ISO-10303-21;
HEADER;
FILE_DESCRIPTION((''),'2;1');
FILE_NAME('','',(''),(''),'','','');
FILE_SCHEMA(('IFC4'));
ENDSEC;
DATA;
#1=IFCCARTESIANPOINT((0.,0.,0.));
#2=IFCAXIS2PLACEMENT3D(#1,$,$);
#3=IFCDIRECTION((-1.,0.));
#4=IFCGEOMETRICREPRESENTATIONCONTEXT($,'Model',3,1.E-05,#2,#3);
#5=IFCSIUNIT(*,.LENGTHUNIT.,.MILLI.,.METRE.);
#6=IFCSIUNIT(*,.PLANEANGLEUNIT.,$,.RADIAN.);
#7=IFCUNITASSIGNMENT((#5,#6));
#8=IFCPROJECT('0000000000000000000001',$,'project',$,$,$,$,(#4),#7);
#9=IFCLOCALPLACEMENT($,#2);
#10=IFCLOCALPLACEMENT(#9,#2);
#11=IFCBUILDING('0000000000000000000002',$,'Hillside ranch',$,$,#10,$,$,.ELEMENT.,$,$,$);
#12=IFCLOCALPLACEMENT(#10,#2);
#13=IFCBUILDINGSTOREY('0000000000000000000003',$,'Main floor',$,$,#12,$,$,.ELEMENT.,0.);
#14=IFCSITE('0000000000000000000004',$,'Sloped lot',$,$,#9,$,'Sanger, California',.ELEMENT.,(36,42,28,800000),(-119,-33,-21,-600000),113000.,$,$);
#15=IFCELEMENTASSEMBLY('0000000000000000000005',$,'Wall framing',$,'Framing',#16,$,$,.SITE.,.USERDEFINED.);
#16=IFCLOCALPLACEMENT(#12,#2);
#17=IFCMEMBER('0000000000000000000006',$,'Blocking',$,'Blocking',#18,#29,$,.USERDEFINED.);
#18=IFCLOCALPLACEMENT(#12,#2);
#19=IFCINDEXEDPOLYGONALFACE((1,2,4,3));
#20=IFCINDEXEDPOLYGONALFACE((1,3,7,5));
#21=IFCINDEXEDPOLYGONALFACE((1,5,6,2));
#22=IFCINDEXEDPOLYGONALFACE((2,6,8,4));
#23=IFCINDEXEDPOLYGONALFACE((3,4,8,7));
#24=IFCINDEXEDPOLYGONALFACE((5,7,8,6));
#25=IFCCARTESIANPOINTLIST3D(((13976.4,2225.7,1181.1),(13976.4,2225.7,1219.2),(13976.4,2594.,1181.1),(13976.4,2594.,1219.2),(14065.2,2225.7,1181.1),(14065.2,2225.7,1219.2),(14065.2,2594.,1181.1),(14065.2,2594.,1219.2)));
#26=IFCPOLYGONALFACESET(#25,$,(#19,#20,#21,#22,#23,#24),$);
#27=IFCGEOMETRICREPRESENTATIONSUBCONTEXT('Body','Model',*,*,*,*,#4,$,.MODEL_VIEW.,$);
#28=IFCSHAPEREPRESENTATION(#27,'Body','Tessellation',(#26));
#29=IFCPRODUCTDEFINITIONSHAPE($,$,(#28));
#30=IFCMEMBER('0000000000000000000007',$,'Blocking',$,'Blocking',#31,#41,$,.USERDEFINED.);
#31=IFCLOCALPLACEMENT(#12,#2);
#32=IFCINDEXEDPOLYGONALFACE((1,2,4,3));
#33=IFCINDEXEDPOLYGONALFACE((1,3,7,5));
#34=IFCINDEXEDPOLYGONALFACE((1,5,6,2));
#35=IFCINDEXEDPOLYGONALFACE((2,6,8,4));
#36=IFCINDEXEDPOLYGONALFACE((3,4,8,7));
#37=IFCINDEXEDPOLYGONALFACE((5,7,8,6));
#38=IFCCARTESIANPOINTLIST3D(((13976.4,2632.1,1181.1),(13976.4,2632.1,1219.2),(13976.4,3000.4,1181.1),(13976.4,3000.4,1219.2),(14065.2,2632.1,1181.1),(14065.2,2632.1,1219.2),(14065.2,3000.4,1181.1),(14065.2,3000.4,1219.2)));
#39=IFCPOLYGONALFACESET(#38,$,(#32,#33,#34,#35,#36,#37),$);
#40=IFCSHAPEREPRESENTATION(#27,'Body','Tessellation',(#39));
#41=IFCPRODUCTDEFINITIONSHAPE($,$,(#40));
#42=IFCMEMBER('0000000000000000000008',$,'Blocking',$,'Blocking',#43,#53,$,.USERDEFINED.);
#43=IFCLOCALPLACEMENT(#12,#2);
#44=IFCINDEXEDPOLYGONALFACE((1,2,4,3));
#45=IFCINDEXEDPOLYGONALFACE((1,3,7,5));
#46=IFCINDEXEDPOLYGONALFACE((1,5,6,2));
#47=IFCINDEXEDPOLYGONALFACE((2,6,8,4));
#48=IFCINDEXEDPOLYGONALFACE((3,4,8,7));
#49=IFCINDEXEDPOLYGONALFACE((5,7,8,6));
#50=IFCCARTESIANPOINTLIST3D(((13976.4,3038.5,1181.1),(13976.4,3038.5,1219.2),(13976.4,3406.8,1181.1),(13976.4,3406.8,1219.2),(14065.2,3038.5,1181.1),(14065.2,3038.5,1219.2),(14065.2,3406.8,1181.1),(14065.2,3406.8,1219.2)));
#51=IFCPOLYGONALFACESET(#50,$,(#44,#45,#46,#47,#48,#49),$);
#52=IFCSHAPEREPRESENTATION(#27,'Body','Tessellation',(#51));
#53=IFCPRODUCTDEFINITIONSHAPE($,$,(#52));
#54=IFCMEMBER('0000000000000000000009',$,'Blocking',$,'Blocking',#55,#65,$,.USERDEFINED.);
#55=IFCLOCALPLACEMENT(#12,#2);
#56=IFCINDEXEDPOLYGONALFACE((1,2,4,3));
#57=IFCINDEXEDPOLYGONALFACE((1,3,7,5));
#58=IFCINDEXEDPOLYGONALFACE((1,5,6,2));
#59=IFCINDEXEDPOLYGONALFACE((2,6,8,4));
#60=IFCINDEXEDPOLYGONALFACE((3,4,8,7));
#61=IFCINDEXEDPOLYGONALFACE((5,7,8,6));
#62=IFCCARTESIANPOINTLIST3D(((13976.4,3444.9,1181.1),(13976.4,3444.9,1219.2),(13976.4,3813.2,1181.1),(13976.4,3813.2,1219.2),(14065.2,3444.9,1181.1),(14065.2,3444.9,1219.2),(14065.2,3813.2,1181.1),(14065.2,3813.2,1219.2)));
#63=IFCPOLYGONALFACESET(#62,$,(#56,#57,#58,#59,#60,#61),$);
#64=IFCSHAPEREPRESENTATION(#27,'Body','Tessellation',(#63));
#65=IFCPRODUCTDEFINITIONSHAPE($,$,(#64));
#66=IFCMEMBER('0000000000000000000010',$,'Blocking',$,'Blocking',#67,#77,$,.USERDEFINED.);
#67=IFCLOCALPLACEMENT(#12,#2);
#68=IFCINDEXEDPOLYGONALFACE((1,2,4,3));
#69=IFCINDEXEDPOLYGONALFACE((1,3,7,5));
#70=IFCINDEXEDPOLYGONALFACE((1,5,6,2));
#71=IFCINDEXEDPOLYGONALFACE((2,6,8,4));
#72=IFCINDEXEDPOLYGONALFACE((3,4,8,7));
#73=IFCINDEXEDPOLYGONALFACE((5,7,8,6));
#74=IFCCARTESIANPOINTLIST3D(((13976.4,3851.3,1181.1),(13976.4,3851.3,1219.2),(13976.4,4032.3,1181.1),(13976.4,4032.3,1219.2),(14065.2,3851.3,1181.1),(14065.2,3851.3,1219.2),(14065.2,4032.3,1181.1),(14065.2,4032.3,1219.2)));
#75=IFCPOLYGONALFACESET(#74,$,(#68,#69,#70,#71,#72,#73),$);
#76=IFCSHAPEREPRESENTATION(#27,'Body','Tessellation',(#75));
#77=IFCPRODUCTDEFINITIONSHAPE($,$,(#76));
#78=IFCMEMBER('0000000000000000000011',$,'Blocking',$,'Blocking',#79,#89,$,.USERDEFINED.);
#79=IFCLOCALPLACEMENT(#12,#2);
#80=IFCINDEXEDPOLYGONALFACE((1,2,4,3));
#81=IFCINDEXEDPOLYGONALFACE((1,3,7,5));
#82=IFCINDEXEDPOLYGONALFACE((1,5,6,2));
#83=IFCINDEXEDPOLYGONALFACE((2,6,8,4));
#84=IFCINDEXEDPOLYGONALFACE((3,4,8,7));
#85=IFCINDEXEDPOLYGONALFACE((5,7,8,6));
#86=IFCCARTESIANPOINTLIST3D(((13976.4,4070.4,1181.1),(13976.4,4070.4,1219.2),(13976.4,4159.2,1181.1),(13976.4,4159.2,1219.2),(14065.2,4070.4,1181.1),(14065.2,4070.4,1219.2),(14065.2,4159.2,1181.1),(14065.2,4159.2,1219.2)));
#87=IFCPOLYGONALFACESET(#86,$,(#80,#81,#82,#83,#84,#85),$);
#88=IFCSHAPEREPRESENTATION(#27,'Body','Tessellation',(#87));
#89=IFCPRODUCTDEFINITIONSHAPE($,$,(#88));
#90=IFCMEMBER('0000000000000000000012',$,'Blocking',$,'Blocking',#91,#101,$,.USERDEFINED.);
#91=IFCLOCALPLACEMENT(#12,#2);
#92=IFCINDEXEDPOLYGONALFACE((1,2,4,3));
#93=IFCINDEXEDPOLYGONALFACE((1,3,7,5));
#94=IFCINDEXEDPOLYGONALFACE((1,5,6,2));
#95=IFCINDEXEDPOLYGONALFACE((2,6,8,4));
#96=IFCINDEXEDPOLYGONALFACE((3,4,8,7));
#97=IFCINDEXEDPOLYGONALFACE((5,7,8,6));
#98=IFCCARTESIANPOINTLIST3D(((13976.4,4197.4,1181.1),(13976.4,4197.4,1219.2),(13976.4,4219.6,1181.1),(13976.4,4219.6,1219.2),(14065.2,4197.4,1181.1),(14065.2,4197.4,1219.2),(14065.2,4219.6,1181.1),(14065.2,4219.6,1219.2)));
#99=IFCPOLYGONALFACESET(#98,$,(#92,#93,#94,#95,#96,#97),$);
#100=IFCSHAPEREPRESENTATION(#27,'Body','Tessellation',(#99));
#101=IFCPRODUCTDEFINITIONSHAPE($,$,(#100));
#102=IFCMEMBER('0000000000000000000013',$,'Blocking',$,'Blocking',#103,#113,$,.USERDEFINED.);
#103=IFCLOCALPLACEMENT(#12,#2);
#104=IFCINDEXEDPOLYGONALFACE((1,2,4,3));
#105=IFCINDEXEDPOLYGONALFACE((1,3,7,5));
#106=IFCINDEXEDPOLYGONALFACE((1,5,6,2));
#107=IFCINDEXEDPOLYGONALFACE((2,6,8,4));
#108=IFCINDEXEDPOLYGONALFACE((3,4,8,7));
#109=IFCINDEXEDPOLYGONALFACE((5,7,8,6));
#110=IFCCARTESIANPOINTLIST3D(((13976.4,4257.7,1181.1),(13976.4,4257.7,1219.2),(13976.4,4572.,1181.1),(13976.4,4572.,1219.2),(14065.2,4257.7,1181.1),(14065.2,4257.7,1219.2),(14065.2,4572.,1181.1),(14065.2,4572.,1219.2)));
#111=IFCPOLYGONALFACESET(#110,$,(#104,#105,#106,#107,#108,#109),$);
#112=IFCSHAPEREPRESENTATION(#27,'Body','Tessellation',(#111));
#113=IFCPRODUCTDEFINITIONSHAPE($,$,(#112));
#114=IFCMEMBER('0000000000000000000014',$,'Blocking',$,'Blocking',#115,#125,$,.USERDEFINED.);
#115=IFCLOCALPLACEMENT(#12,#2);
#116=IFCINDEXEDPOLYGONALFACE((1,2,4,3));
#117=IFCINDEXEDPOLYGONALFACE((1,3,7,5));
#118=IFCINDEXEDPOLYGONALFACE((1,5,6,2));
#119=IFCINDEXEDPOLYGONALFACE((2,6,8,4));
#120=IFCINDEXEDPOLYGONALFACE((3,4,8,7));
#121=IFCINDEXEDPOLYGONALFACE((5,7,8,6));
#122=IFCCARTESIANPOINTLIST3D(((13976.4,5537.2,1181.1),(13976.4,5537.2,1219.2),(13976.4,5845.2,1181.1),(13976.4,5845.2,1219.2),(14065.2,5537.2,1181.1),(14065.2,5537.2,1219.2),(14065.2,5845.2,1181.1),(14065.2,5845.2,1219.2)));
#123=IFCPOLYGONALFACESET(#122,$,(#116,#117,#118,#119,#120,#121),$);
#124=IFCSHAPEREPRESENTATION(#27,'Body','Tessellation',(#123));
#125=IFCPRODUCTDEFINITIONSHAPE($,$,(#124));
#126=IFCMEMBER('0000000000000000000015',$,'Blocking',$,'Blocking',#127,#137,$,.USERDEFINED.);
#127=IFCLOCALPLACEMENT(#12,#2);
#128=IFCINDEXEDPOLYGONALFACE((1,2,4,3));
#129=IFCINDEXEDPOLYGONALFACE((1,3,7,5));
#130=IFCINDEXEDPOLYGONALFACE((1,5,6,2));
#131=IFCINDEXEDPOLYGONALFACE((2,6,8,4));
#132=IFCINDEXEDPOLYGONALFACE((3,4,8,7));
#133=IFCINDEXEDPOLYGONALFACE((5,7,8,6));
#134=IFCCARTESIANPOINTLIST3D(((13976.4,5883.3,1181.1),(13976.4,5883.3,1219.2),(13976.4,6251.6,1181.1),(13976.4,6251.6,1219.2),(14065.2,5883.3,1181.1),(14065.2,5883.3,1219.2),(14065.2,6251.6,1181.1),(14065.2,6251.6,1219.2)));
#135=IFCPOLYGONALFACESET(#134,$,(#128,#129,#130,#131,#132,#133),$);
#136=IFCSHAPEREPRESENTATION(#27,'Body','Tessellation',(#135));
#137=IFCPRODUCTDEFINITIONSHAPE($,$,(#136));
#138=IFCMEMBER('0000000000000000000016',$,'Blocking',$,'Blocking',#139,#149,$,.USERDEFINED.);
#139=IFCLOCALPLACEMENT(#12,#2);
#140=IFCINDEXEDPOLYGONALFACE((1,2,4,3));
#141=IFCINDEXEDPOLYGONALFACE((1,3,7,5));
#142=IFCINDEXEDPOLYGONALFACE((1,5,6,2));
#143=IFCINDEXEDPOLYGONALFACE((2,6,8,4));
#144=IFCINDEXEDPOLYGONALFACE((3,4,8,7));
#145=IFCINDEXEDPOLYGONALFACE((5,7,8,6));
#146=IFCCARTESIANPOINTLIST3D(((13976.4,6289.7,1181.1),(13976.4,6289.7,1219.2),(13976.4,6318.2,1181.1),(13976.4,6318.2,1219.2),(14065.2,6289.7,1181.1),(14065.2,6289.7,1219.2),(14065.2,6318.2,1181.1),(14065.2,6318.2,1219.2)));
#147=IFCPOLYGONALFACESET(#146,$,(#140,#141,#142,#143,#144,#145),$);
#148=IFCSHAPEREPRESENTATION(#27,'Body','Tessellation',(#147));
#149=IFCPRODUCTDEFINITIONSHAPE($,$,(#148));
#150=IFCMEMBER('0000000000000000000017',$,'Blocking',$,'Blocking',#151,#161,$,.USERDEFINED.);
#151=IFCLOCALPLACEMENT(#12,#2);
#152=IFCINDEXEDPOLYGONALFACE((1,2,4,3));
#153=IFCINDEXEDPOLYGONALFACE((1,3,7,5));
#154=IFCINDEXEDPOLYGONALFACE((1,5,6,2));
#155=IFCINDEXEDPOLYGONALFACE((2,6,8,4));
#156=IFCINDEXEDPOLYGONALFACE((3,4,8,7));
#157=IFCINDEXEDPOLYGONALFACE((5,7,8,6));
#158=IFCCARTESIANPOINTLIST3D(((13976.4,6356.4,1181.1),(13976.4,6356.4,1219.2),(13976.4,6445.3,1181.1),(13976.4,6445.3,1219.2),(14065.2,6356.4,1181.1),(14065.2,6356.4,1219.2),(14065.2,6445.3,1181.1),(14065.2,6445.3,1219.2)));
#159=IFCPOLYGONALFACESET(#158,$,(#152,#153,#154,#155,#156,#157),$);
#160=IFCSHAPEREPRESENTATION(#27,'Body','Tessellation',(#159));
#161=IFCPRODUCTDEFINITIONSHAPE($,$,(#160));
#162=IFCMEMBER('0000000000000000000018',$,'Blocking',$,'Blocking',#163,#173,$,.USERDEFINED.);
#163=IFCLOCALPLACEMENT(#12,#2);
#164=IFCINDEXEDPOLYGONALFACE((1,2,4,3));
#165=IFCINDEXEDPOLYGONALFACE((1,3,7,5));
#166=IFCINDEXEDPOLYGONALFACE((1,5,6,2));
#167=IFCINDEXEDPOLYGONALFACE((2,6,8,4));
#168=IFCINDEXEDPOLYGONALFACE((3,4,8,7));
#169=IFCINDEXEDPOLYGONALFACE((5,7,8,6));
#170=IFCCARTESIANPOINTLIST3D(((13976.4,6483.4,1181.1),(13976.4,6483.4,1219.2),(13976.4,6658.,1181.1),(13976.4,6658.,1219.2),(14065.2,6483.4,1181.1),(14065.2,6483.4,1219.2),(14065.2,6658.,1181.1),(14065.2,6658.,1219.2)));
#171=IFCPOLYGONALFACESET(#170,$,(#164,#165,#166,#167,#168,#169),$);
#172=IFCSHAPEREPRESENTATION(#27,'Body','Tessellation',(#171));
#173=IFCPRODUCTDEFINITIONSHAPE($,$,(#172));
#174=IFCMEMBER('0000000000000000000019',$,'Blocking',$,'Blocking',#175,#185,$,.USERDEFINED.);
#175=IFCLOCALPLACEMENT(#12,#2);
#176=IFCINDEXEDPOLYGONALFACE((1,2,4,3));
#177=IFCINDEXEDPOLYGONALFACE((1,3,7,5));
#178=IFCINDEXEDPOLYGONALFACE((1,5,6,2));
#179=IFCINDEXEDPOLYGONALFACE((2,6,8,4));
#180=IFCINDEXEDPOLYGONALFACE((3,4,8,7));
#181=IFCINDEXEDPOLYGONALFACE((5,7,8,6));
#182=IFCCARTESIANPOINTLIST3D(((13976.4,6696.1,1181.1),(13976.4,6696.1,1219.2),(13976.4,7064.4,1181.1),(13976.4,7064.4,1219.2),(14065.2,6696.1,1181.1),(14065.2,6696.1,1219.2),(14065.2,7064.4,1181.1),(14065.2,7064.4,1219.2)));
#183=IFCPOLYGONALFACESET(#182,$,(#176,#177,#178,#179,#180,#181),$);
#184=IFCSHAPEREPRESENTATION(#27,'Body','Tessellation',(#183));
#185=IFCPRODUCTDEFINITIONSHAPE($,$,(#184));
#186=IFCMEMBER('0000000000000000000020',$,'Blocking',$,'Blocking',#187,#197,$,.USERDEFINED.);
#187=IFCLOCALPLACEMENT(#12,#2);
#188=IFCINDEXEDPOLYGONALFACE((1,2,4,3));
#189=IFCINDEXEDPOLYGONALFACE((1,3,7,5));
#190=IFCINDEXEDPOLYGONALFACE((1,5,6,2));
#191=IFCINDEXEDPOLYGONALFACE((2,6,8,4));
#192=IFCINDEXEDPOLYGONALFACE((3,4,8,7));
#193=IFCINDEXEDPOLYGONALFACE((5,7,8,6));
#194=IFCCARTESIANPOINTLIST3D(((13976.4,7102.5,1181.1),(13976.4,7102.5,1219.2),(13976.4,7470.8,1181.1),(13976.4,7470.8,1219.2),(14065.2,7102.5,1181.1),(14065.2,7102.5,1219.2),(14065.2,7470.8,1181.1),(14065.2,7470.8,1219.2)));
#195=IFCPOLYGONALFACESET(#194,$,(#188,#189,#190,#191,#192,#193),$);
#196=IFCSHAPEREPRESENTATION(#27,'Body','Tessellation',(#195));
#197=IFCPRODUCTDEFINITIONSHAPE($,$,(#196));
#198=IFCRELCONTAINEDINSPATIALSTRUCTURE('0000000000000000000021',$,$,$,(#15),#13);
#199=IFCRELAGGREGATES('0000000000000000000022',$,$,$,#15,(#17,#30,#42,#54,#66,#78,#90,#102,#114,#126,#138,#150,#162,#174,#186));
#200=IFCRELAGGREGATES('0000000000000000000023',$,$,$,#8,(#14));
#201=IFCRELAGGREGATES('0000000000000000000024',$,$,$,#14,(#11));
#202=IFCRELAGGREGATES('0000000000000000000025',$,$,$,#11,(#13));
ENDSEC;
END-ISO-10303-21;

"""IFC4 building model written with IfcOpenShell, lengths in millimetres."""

from ifc_helpers import new_model, si_unit, direction, frame, origin, origin_with_axes, place, context, subcontext, project, spatial, polyline, outline, extrude, element, aggregate, save


model = new_model("IFC4")

# Units and contexts
model_context = context("Model", 3, precision=1e-05, world=origin(), true_north=direction((-1.0, 0.0)))
body_context = subcontext(model_context, "Body", "Model", "MODEL_VIEW")
ifc_project = project(units=[si_unit("LENGTHUNIT", "METRE", prefix="MILLI"), si_unit("PLANEANGLEUNIT", "RADIAN")], contexts=[model_context])

# Site, building, storey
site_placement = place(None, origin())
site = spatial("IfcSite", under=ifc_project, at=site_placement, Name="Sloped lot", LongName="Sanger, California", CompositionType="ELEMENT", RefLatitude=(36, 42, 28, 800000), RefLongitude=(-119, -33, -21, -600000), RefElevation=113000.0)
building_placement = place(site_placement, origin())
building = spatial("IfcBuilding", under=site, at=building_placement, Name="Hillside ranch", CompositionType="ELEMENT")
storey_placement = place(building_placement, origin())
storey = spatial("IfcBuildingStorey", under=building, at=storey_placement, Name="Main floor", CompositionType="ELEMENT", Elevation=0.0)

# Element assembly, members
assembly_1_placement = place(storey_placement, origin_with_axes())
assembly_1 = element("IfcElementAssembly", 1, at=assembly_1_placement, inside=storey, Name="Wall framing", ObjectType="Framing", AssemblyPlace="SITE", PredefinedType="USERDEFINED")
member_1_placement = place(storey_placement, origin_with_axes())
member_1 = element("IfcMember", 2, at=member_1_placement, Name="Blocking", ObjectType="Blocking", PredefinedType="USERDEFINED", context=body_context, shape_type="SweptSolid", body=[
    extrude(outline(polyline([(0.0, 0.0), (368.3, 0.0), (368.3, 88.9), (0.0, 88.9), (0.0, 0.0)])), frame((14065.2, 2225.7, 1181.1), z_axis=(0.0, 0.0, 1.0), x_axis=(0.0, 1.0, 0.0)), (0.0, 0.0, 1.0), 38.1),
])
member_2_placement = place(storey_placement, origin_with_axes())
member_2 = element("IfcMember", 3, at=member_2_placement, Name="Blocking", ObjectType="Blocking", PredefinedType="USERDEFINED", context=body_context, shape_type="SweptSolid", body=[
    extrude(outline(polyline([(0.0, 0.0), (368.3, 0.0), (368.3, 88.9), (0.0, 88.9), (0.0, 0.0)])), frame((14065.2, 2632.1, 1181.1), z_axis=(0.0, 0.0, 1.0), x_axis=(0.0, 1.0, 0.0)), (0.0, 0.0, 1.0), 38.1),
])
member_3_placement = place(storey_placement, origin_with_axes())
member_3 = element("IfcMember", 4, at=member_3_placement, Name="Blocking", ObjectType="Blocking", PredefinedType="USERDEFINED", context=body_context, shape_type="SweptSolid", body=[
    extrude(outline(polyline([(0.0, 0.0), (368.3, 0.0), (368.3, 88.9), (0.0, 88.9), (0.0, 0.0)])), frame((14065.2, 3038.5, 1181.1), z_axis=(0.0, 0.0, 1.0), x_axis=(0.0, 1.0, 0.0)), (0.0, 0.0, 1.0), 38.1),
])
member_4_placement = place(storey_placement, origin_with_axes())
member_4 = element("IfcMember", 5, at=member_4_placement, Name="Blocking", ObjectType="Blocking", PredefinedType="USERDEFINED", context=body_context, shape_type="SweptSolid", body=[
    extrude(outline(polyline([(0.0, 0.0), (368.3, 0.0), (368.3, 88.9), (0.0, 88.9), (0.0, 0.0)])), frame((14065.2, 3444.9, 1181.1), z_axis=(0.0, 0.0, 1.0), x_axis=(0.0, 1.0, 0.0)), (0.0, 0.0, 1.0), 38.1),
])
member_5_placement = place(storey_placement, origin_with_axes())
member_5 = element("IfcMember", 6, at=member_5_placement, Name="Blocking", ObjectType="Blocking", PredefinedType="USERDEFINED", context=body_context, shape_type="SweptSolid", body=[
    extrude(outline(polyline([(0.0, 0.0), (181.0, 0.0), (181.0, 88.9), (0.0, 88.9), (0.0, 0.0)])), frame((14065.2, 3851.3, 1181.1), z_axis=(0.0, 0.0, 1.0), x_axis=(0.0, 1.0, 0.0)), (0.0, 0.0, 1.0), 38.1),
])
member_6_placement = place(storey_placement, origin_with_axes())
member_6 = element("IfcMember", 7, at=member_6_placement, Name="Blocking", ObjectType="Blocking", PredefinedType="USERDEFINED", context=body_context, shape_type="SweptSolid", body=[
    extrude(outline(polyline([(0.0, 0.0), (88.9, 0.0), (88.9, 88.9), (0.0, 88.9), (0.0, 0.0)])), frame((14065.2, 4070.3, 1181.1), z_axis=(0.0, 0.0, 1.0), x_axis=(0.0, 1.0, 0.0)), (0.0, 0.0, 1.0), 38.1),
])
member_7_placement = place(storey_placement, origin_with_axes())
member_7 = element("IfcMember", 8, at=member_7_placement, Name="Blocking", ObjectType="Blocking", PredefinedType="USERDEFINED", context=body_context, shape_type="SweptSolid", body=[
    extrude(outline(polyline([(0.0, 0.0), (22.2, 0.0), (22.2, 88.9), (0.0, 88.9), (0.0, 0.0)])), frame((14065.2, 4197.4, 1181.1), z_axis=(0.0, 0.0, 1.0), x_axis=(0.0, 1.0, 0.0)), (0.0, 0.0, 1.0), 38.1),
])
member_8_placement = place(storey_placement, origin_with_axes())
member_8 = element("IfcMember", 9, at=member_8_placement, Name="Blocking", ObjectType="Blocking", PredefinedType="USERDEFINED", context=body_context, shape_type="SweptSolid", body=[
    extrude(outline(polyline([(0.0, 0.0), (314.3, 0.0), (314.3, 88.9), (0.0, 88.9), (0.0, 0.0)])), frame((14065.2, 4257.7, 1181.1), z_axis=(0.0, 0.0, 1.0), x_axis=(0.0, 1.0, 0.0)), (0.0, 0.0, 1.0), 38.1),
])
member_9_placement = place(storey_placement, origin_with_axes())
member_9 = element("IfcMember", 10, at=member_9_placement, Name="Blocking", ObjectType="Blocking", PredefinedType="USERDEFINED", context=body_context, shape_type="SweptSolid", body=[
    extrude(outline(polyline([(0.0, 0.0), (308.0, 0.0), (308.0, 88.9), (0.0, 88.9), (0.0, 0.0)])), frame((14065.2, 5537.2, 1181.1), z_axis=(0.0, 0.0, 1.0), x_axis=(0.0, 1.0, 0.0)), (0.0, 0.0, 1.0), 38.1),
])
member_10_placement = place(storey_placement, origin_with_axes())
member_10 = element("IfcMember", 11, at=member_10_placement, Name="Blocking", ObjectType="Blocking", PredefinedType="USERDEFINED", context=body_context, shape_type="SweptSolid", body=[
    extrude(outline(polyline([(0.0, 0.0), (368.3, 0.0), (368.3, 88.9), (0.0, 88.9), (0.0, 0.0)])), frame((14065.2, 5883.3, 1181.1), z_axis=(0.0, 0.0, 1.0), x_axis=(0.0, 1.0, 0.0)), (0.0, 0.0, 1.0), 38.1),
])
member_11_placement = place(storey_placement, origin_with_axes())
member_11 = element("IfcMember", 12, at=member_11_placement, Name="Blocking", ObjectType="Blocking", PredefinedType="USERDEFINED", context=body_context, shape_type="SweptSolid", body=[
    extrude(outline(polyline([(0.0, 0.0), (28.6, 0.0), (28.6, 88.9), (0.0, 88.9), (0.0, 0.0)])), frame((14065.2, 6289.7, 1181.1), z_axis=(0.0, 0.0, 1.0), x_axis=(0.0, 1.0, 0.0)), (0.0, 0.0, 1.0), 38.1),
])
member_12_placement = place(storey_placement, origin_with_axes())
member_12 = element("IfcMember", 13, at=member_12_placement, Name="Blocking", ObjectType="Blocking", PredefinedType="USERDEFINED", context=body_context, shape_type="SweptSolid", body=[
    extrude(outline(polyline([(0.0, 0.0), (88.9, 0.0), (88.9, 88.9), (0.0, 88.9), (0.0, 0.0)])), frame((14065.2, 6356.4, 1181.1), z_axis=(0.0, 0.0, 1.0), x_axis=(0.0, 1.0, 0.0)), (0.0, 0.0, 1.0), 38.1),
])
member_13_placement = place(storey_placement, origin_with_axes())
member_13 = element("IfcMember", 14, at=member_13_placement, Name="Blocking", ObjectType="Blocking", PredefinedType="USERDEFINED", context=body_context, shape_type="SweptSolid", body=[
    extrude(outline(polyline([(0.0, 0.0), (174.6, 0.0), (174.6, 88.9), (0.0, 88.9), (0.0, 0.0)])), frame((14065.2, 6483.4, 1181.1), z_axis=(0.0, 0.0, 1.0), x_axis=(0.0, 1.0, 0.0)), (0.0, 0.0, 1.0), 38.1),
])
member_14_placement = place(storey_placement, origin_with_axes())
member_14 = element("IfcMember", 15, at=member_14_placement, Name="Blocking", ObjectType="Blocking", PredefinedType="USERDEFINED", context=body_context, shape_type="SweptSolid", body=[
    extrude(outline(polyline([(0.0, 0.0), (368.3, 0.0), (368.3, 88.9), (0.0, 88.9), (0.0, 0.0)])), frame((14065.2, 6696.1, 1181.1), z_axis=(0.0, 0.0, 1.0), x_axis=(0.0, 1.0, 0.0)), (0.0, 0.0, 1.0), 38.1),
])
member_15_placement = place(storey_placement, origin_with_axes())
member_15 = element("IfcMember", 16, at=member_15_placement, Name="Blocking", ObjectType="Blocking", PredefinedType="USERDEFINED", context=body_context, shape_type="SweptSolid", body=[
    extrude(outline(polyline([(0.0, 0.0), (368.3, 0.0), (368.3, 88.9), (0.0, 88.9), (0.0, 0.0)])), frame((14065.2, 7102.5, 1181.1), z_axis=(0.0, 0.0, 1.0), x_axis=(0.0, 1.0, 0.0)), (0.0, 0.0, 1.0), 38.1),
])
aggregate(assembly_1, [member_1, member_2, member_3, member_4, member_5, member_6, member_7, member_8, member_9, member_10, member_11, member_12, member_13, member_14, member_15])

save(model, "model.ifc")
